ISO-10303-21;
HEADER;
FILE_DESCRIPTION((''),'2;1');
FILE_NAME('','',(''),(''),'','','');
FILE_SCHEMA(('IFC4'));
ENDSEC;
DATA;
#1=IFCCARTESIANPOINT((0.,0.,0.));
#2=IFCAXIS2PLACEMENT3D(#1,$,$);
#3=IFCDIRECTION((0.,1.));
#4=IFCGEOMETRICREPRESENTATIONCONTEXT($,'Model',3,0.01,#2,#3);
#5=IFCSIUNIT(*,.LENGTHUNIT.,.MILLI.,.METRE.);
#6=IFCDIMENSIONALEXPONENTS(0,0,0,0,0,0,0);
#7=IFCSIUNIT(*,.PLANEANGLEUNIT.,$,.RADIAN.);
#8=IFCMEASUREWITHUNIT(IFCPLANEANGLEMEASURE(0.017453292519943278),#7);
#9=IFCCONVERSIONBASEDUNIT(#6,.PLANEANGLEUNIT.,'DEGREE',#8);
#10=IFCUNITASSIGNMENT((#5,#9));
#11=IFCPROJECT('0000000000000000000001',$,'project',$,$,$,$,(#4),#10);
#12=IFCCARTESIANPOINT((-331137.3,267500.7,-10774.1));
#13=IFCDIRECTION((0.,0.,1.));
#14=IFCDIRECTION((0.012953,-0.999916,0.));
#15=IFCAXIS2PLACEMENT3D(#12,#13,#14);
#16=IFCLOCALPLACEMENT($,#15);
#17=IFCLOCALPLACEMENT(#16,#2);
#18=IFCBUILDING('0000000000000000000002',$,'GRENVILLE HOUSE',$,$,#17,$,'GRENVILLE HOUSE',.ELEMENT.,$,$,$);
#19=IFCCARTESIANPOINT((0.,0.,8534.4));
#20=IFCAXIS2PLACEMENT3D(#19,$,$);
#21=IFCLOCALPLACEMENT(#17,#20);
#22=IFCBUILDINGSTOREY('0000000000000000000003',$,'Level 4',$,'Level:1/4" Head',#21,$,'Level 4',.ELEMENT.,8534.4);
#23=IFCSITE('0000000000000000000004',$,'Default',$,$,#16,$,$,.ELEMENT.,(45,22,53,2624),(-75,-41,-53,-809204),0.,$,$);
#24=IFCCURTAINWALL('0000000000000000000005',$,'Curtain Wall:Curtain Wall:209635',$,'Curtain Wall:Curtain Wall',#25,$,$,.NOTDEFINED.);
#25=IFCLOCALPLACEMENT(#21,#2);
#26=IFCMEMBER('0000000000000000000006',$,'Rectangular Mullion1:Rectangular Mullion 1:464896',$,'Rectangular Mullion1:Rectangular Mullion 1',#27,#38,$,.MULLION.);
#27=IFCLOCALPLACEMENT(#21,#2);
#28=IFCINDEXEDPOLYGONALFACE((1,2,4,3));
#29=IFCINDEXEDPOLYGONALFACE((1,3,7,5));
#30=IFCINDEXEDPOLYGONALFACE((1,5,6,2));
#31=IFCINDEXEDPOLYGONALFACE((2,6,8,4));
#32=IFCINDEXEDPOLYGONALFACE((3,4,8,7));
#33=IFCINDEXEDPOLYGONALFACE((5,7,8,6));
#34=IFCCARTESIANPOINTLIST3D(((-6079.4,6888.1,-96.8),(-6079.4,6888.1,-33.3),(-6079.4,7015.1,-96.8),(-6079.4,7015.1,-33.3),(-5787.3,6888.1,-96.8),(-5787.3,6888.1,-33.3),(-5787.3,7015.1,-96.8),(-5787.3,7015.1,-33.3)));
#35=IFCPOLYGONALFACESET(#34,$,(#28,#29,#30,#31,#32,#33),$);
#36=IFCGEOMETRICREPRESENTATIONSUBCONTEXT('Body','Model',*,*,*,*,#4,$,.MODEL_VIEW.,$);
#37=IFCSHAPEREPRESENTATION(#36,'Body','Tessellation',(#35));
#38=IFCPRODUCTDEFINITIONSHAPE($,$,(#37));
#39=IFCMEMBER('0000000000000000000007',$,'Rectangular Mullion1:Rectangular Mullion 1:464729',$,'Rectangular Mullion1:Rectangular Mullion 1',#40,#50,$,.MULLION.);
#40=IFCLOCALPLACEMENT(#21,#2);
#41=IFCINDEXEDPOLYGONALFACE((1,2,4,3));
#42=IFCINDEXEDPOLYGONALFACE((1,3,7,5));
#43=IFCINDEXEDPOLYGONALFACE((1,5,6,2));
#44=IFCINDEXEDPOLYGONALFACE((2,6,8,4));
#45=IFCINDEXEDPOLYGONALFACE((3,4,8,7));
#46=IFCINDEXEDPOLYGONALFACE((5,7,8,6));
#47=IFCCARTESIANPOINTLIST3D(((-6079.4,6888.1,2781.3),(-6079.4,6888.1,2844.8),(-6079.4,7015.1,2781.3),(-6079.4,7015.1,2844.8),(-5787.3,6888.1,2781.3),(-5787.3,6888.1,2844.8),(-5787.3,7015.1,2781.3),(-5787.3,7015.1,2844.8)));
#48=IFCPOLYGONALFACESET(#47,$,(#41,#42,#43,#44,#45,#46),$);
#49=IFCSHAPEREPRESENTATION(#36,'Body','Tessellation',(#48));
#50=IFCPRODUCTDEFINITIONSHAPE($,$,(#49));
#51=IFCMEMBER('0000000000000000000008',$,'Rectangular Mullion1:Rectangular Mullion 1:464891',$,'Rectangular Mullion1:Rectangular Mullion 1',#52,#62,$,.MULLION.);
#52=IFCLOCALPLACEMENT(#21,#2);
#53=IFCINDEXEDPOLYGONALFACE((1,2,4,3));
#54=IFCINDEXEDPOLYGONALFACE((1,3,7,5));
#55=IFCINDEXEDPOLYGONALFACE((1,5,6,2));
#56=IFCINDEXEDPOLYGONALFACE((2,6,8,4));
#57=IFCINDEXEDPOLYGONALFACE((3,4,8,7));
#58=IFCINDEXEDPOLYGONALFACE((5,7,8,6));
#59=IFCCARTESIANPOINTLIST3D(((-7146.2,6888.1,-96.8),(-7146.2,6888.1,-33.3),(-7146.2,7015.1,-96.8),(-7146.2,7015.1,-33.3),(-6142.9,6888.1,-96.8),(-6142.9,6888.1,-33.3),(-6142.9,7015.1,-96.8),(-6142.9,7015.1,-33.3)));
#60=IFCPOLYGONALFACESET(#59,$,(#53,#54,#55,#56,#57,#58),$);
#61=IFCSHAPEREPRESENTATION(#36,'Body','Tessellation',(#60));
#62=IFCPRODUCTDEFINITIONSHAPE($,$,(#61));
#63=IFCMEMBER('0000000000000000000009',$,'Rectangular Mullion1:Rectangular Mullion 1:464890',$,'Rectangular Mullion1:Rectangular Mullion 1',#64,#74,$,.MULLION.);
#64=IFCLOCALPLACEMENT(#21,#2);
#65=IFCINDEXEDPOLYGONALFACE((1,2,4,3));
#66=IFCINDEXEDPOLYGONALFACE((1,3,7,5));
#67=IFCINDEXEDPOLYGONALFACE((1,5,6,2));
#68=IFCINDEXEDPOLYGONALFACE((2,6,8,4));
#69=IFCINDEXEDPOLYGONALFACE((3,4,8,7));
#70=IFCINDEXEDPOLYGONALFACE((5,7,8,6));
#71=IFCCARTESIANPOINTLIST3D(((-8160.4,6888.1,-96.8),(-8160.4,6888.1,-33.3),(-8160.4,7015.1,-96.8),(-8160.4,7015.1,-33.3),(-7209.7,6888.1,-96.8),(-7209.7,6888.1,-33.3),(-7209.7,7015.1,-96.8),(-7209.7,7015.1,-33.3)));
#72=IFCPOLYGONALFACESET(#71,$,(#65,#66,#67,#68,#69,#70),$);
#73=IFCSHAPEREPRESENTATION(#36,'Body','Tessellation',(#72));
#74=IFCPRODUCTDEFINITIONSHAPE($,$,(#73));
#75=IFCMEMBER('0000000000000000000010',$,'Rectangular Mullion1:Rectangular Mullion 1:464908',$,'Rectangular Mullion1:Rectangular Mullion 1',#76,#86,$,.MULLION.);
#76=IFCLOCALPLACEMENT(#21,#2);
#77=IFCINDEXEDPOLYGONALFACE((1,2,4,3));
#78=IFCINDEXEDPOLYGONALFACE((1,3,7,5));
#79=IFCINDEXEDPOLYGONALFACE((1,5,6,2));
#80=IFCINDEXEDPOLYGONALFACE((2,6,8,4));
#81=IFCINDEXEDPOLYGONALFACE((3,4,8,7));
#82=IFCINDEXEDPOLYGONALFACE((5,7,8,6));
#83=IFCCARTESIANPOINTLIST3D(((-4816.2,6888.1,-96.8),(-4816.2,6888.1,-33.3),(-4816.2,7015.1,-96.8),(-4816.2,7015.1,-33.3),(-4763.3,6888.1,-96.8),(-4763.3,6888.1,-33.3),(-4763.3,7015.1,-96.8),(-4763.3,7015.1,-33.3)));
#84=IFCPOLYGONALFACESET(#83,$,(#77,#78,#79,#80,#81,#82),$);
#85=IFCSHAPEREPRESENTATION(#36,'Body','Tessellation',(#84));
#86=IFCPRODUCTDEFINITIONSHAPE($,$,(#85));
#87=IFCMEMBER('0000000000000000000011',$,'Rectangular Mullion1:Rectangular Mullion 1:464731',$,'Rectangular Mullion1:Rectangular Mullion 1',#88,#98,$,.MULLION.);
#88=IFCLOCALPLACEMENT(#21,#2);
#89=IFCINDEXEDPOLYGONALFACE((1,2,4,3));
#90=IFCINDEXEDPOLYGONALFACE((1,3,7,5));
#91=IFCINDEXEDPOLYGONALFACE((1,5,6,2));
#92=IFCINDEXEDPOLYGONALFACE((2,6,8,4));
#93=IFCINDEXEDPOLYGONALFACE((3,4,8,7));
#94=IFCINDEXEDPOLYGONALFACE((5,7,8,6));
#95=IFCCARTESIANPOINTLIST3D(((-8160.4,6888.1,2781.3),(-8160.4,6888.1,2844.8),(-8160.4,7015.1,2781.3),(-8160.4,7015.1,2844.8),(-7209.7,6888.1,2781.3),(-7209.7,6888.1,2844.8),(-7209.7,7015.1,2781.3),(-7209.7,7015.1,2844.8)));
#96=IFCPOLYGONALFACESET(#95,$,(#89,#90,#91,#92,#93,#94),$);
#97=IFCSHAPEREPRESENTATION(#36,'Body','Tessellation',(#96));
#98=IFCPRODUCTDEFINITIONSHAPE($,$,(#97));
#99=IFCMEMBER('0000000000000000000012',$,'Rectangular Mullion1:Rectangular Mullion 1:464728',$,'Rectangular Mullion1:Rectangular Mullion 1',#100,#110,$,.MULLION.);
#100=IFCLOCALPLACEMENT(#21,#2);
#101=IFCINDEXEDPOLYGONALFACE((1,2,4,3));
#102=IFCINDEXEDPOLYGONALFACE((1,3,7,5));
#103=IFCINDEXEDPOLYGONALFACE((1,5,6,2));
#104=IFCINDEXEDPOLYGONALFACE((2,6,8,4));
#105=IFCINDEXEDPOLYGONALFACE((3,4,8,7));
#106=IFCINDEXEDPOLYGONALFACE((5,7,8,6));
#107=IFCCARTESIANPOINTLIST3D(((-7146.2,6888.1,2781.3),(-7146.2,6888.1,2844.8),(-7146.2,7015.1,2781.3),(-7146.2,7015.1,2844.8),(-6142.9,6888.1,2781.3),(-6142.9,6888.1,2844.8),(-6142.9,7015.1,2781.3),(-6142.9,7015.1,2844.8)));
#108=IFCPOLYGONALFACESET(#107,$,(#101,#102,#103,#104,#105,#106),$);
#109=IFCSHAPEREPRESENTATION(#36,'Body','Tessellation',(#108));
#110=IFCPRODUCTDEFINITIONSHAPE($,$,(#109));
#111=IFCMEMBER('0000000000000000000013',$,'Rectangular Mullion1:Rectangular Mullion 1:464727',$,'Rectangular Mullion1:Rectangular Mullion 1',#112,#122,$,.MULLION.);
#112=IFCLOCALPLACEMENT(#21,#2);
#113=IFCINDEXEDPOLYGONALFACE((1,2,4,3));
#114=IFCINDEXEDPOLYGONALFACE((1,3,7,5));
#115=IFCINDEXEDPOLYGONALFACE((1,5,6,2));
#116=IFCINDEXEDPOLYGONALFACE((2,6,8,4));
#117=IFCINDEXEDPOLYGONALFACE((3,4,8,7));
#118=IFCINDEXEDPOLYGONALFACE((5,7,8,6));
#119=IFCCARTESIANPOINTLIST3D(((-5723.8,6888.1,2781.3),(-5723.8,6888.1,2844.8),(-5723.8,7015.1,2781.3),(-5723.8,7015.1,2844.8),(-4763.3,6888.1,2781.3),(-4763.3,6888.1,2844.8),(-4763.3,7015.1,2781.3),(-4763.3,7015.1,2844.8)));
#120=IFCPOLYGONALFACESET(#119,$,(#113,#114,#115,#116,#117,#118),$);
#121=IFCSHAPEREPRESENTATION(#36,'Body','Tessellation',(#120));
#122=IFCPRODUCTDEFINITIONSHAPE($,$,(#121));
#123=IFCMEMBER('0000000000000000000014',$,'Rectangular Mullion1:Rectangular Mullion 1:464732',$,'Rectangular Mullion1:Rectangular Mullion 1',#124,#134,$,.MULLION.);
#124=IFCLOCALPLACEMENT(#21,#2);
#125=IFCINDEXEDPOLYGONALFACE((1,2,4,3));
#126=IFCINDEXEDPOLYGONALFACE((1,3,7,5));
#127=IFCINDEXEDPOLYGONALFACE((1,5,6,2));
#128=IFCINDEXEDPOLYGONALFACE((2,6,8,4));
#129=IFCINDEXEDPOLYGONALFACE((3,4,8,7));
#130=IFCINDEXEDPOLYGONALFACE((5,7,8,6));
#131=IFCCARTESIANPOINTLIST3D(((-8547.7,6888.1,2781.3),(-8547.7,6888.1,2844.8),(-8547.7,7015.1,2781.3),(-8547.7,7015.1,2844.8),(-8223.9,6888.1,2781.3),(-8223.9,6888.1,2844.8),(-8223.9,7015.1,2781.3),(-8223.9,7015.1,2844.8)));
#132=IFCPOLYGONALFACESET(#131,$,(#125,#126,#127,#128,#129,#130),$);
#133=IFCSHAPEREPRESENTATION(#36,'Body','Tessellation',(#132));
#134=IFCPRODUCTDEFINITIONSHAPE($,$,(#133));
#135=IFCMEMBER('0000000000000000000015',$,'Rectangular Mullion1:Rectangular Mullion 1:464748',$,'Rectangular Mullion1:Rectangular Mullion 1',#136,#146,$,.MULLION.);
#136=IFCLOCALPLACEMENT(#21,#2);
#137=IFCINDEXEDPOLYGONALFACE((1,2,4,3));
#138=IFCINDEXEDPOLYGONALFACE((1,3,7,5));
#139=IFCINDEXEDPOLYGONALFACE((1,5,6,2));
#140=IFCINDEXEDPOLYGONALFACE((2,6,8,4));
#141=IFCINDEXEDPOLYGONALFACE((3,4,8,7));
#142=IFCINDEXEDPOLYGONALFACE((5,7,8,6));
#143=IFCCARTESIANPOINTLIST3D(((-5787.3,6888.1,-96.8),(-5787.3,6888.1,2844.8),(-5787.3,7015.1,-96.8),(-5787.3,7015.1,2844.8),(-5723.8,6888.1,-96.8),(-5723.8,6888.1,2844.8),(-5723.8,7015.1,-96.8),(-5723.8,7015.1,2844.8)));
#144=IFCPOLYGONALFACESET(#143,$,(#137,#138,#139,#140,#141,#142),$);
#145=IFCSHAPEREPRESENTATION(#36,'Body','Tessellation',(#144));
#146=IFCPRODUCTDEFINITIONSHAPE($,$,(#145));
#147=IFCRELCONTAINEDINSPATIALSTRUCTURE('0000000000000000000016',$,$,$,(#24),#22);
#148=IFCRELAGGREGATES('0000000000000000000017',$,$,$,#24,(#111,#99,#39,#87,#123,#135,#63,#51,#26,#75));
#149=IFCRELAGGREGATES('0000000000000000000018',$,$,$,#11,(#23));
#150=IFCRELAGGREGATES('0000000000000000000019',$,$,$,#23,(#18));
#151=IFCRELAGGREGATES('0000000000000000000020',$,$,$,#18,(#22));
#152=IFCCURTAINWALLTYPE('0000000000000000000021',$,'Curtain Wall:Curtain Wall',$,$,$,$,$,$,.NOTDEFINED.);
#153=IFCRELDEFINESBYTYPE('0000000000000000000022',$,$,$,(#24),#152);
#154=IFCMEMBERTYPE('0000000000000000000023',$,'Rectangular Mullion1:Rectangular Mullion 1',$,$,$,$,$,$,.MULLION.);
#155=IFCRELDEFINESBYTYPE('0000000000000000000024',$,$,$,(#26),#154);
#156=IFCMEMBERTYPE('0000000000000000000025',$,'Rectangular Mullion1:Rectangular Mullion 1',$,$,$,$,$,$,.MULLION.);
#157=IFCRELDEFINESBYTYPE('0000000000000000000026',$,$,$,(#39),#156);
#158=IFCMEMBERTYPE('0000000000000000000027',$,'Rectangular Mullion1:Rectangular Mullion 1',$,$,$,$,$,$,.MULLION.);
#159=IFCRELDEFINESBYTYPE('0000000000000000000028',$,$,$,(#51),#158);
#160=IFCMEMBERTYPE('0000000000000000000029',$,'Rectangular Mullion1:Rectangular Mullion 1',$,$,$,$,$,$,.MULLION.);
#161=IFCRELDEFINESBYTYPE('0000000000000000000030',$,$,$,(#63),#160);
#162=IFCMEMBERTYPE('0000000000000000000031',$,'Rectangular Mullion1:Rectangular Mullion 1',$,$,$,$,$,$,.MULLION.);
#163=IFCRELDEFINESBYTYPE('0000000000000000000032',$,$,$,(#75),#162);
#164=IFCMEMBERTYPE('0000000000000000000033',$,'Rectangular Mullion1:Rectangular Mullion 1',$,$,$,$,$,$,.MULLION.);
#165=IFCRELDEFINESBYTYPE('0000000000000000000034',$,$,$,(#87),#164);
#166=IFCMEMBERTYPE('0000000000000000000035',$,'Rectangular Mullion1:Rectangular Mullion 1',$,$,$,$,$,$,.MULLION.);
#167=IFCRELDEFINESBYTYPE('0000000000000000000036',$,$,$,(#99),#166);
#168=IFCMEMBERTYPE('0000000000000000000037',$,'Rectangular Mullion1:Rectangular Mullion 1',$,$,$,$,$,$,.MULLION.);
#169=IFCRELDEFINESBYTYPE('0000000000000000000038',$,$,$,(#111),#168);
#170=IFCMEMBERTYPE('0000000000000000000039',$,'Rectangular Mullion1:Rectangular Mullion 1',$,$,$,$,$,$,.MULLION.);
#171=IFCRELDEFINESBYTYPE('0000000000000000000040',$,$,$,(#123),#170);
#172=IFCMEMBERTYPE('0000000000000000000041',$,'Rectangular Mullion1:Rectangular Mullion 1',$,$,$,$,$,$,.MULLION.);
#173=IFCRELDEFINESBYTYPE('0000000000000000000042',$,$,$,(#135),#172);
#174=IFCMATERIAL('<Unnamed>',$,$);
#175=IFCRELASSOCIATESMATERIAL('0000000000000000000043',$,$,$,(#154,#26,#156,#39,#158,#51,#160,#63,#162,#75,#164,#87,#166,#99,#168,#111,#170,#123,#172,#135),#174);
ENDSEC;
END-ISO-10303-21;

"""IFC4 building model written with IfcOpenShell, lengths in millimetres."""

from ifc_helpers import new_model, entity, si_unit, converted_unit, direction, frame, origin, place, context, subcontext, project, spatial, indexed_curve, outline, extrude, source, transform, mapped, material, type_object, type_shapes, element, aggregate, save


model = new_model("IFC4")

# Units and contexts
model_context = context("Model", 3, precision=0.01, world=origin(), true_north=direction((0.0, 1.0)))
body_context = subcontext(model_context, "Body", "Model", "MODEL_VIEW")
ifc_project = project(units=[si_unit("LENGTHUNIT", "METRE", prefix="MILLI"), converted_unit("PLANEANGLEUNIT", "DEGREE", entity("IfcPlaneAngleMeasure", 0.017453292519943278), si_unit("PLANEANGLEUNIT", "RADIAN"), dimensions=[0, 0, 0, 0, 0, 0, 0])], contexts=[model_context])

# Site, building, storey
site_placement = place(None, frame((-331137.3, 267500.7, -10774.1), z_axis=(0.0, 0.0, 1.0), x_axis=(0.012953, -0.999916, 0.0)))
site = spatial("IfcSite", under=ifc_project, at=site_placement, Name="Default", CompositionType="ELEMENT", RefLatitude=(45, 22, 53, 2624), RefLongitude=(-75, -41, -53, -809204), RefElevation=0.0)
building_placement = place(site_placement, origin())
building = spatial("IfcBuilding", under=site, at=building_placement, Name="GRENVILLE HOUSE", LongName="GRENVILLE HOUSE", CompositionType="ELEMENT")
storey_placement = place(building_placement, frame((0.0, 0.0, 8534.4)))
storey = spatial("IfcBuildingStorey", under=building, at=storey_placement, Name="Level 4", ObjectType="Level:1/4\" Head", LongName="Level 4", CompositionType="ELEMENT", Elevation=8534.4)

# Curtain wall, members
curtain_wall_type = type_object("IfcCurtainWallType", Name="Curtain Wall:Curtain Wall", PredefinedType="NOTDEFINED")
curtain_wall_placement = place(storey_placement, frame((0.0, 0.0, -8534.4)))
curtain_wall = element("IfcCurtainWall", 1, at=curtain_wall_placement, inside=storey, type_object=curtain_wall_type, Name="Curtain Wall:Curtain Wall:209635", ObjectType="Curtain Wall:Curtain Wall", PredefinedType="NOTDEFINED")
ifc_material_1 = material(Name="<Unnamed>")
member_type_1 = type_object("IfcMemberType", Name="Rectangular Mullion1:Rectangular Mullion 1", PredefinedType="MULLION", material=ifc_material_1)
shared_shape_1 = source(origin(), body_context, "Body", "SweptSolid", [
    extrude(outline(indexed_curve([(-31.8, -63.5), (31.8, -63.5), (31.8, 63.5), (-31.8, 63.5), (-31.8, -63.5)], self_intersect=False)), frame((-31.8, 0.0, -292.1), z_axis=(0.0, 0.0, 1.0), x_axis=(-1.0, 0.0, 0.0)), (0.0, 0.0, 1.0), 292.1),
])
type_shapes(member_type_1, [shared_shape_1])
member_1_placement = place(curtain_wall_placement, frame((-5787.3, 6951.6, 8437.6), z_axis=(1.0, 0.0, 0.0), x_axis=(0.0, 0.0, -1.0)))
member_1 = element("IfcMember", 2, at=member_1_placement, type_object=member_type_1, material=ifc_material_1, Name="Rectangular Mullion1:Rectangular Mullion 1:464896", ObjectType="Rectangular Mullion1:Rectangular Mullion 1", PredefinedType="MULLION", context=body_context, shape_type="MappedRepresentation", body=[
    mapped(shared_shape_1, transform((0.0, 0.0, 0.0), scale=1.0)),
])
member_type_2 = type_object("IfcMemberType", Name="Rectangular Mullion1:Rectangular Mullion 1", PredefinedType="MULLION", material=ifc_material_1)
shared_shape_2 = source(origin(), body_context, "Body", "SweptSolid", [
    extrude(outline(indexed_curve([(-31.8, -63.5), (31.8, -63.5), (31.8, 63.5), (-31.8, 63.5), (-31.8, -63.5)], self_intersect=False)), frame((-31.8, 0.0, -292.1), z_axis=(0.0, 0.0, 1.0), x_axis=(-1.0, 0.0, 0.0)), (0.0, 0.0, 1.0), 292.1),
])
type_shapes(member_type_2, [shared_shape_2])
member_2_placement = place(curtain_wall_placement, frame((-6079.4, 6951.6, 11379.2), z_axis=(-1.0, 0.0, 0.0), x_axis=(0.0, 0.0, 1.0)))
member_2 = element("IfcMember", 3, at=member_2_placement, type_object=member_type_2, material=ifc_material_1, Name="Rectangular Mullion1:Rectangular Mullion 1:464729", ObjectType="Rectangular Mullion1:Rectangular Mullion 1", PredefinedType="MULLION", context=body_context, shape_type="MappedRepresentation", body=[
    mapped(shared_shape_2, transform((0.0, 0.0, 0.0), scale=1.0)),
])
member_type_3 = type_object("IfcMemberType", Name="Rectangular Mullion1:Rectangular Mullion 1", PredefinedType="MULLION", material=ifc_material_1)
shared_shape_3 = source(origin(), body_context, "Body", "SweptSolid", [
    extrude(outline(indexed_curve([(-31.8, -63.5), (31.8, -63.5), (31.8, 63.5), (-31.8, 63.5), (-31.8, -63.5)], self_intersect=False)), frame((-31.8, 0.0, -1003.3), z_axis=(0.0, 0.0, 1.0), x_axis=(-1.0, 0.0, 0.0)), (0.0, 0.0, 1.0), 1003.3),
])
type_shapes(member_type_3, [shared_shape_3])
member_3_placement = place(curtain_wall_placement, frame((-6142.9, 6951.6, 8437.6), z_axis=(1.0, 0.0, 0.0), x_axis=(0.0, 0.0, -1.0)))
member_3 = element("IfcMember", 4, at=member_3_placement, type_object=member_type_3, material=ifc_material_1, Name="Rectangular Mullion1:Rectangular Mullion 1:464891", ObjectType="Rectangular Mullion1:Rectangular Mullion 1", PredefinedType="MULLION", context=body_context, shape_type="MappedRepresentation", body=[
    mapped(shared_shape_3, transform((0.0, 0.0, 0.0), scale=1.0)),
])
member_type_4 = type_object("IfcMemberType", Name="Rectangular Mullion1:Rectangular Mullion 1", PredefinedType="MULLION", material=ifc_material_1)
shared_shape_4 = source(origin(), body_context, "Body", "SweptSolid", [
    extrude(outline(indexed_curve([(-31.8, -63.5), (31.8, -63.5), (31.8, 63.5), (-31.8, 63.5), (-31.8, -63.5)], self_intersect=False)), frame((-31.8, 0.0, -950.7), z_axis=(0.0, 0.0, 1.0), x_axis=(-1.0, 0.0, 0.0)), (0.0, 0.0, 1.0), 950.7),
])
type_shapes(member_type_4, [shared_shape_4])
member_4_placement = place(curtain_wall_placement, frame((-7209.7, 6951.6, 8437.6), z_axis=(1.0, 0.0, 0.0), x_axis=(0.0, 0.0, -1.0)))
member_4 = element("IfcMember", 5, at=member_4_placement, type_object=member_type_4, material=ifc_material_1, Name="Rectangular Mullion1:Rectangular Mullion 1:464890", ObjectType="Rectangular Mullion1:Rectangular Mullion 1", PredefinedType="MULLION", context=body_context, shape_type="MappedRepresentation", body=[
    mapped(shared_shape_4, transform((0.0, 0.0, 0.0), scale=1.0)),
])
member_type_5 = type_object("IfcMemberType", Name="Rectangular Mullion1:Rectangular Mullion 1", PredefinedType="MULLION", material=ifc_material_1)
shared_shape_5 = source(origin(), body_context, "Body", "SweptSolid", [
    extrude(outline(indexed_curve([(-31.8, -63.5), (31.8, -63.5), (31.8, 63.5), (-31.8, 63.5), (-31.8, -63.5)], self_intersect=False)), frame((-31.8, 0.0, -52.9), z_axis=(0.0, 0.0, 1.0), x_axis=(-1.0, 0.0, 0.0)), (0.0, 0.0, 1.0), 52.9),
])
type_shapes(member_type_5, [shared_shape_5])
member_5_placement = place(curtain_wall_placement, frame((-4763.3, 6951.6, 8437.6), z_axis=(1.0, 0.0, 0.0), x_axis=(0.0, 0.0, -1.0)))
member_5 = element("IfcMember", 6, at=member_5_placement, type_object=member_type_5, material=ifc_material_1, Name="Rectangular Mullion1:Rectangular Mullion 1:464908", ObjectType="Rectangular Mullion1:Rectangular Mullion 1", PredefinedType="MULLION", context=body_context, shape_type="MappedRepresentation", body=[
    mapped(shared_shape_5, transform((0.0, 0.0, 0.0), scale=1.0)),
])
member_type_6 = type_object("IfcMemberType", Name="Rectangular Mullion1:Rectangular Mullion 1", PredefinedType="MULLION", material=ifc_material_1)
shared_shape_6 = source(origin(), body_context, "Body", "SweptSolid", [
    extrude(outline(indexed_curve([(-31.8, -63.5), (31.8, -63.5), (31.8, 63.5), (-31.8, 63.5), (-31.8, -63.5)], self_intersect=False)), frame((-31.8, 0.0, -950.7), z_axis=(0.0, 0.0, 1.0), x_axis=(-1.0, 0.0, 0.0)), (0.0, 0.0, 1.0), 950.7),
])
type_shapes(member_type_6, [shared_shape_6])
member_6_placement = place(curtain_wall_placement, frame((-8160.4, 6951.6, 11379.2), z_axis=(-1.0, 0.0, 0.0), x_axis=(0.0, 0.0, 1.0)))
member_6 = element("IfcMember", 7, at=member_6_placement, type_object=member_type_6, material=ifc_material_1, Name="Rectangular Mullion1:Rectangular Mullion 1:464731", ObjectType="Rectangular Mullion1:Rectangular Mullion 1", PredefinedType="MULLION", context=body_context, shape_type="MappedRepresentation", body=[
    mapped(shared_shape_6, transform((0.0, 0.0, 0.0), scale=1.0)),
])
member_type_7 = type_object("IfcMemberType", Name="Rectangular Mullion1:Rectangular Mullion 1", PredefinedType="MULLION", material=ifc_material_1)
shared_shape_7 = source(origin(), body_context, "Body", "SweptSolid", [
    extrude(outline(indexed_curve([(-31.8, -63.5), (31.8, -63.5), (31.8, 63.5), (-31.8, 63.5), (-31.8, -63.5)], self_intersect=False)), frame((-31.8, 0.0, -1003.3), z_axis=(0.0, 0.0, 1.0), x_axis=(-1.0, 0.0, 0.0)), (0.0, 0.0, 1.0), 1003.3),
])
type_shapes(member_type_7, [shared_shape_7])
member_7_placement = place(curtain_wall_placement, frame((-7146.2, 6951.6, 11379.2), z_axis=(-1.0, 0.0, 0.0), x_axis=(0.0, 0.0, 1.0)))
member_7 = element("IfcMember", 8, at=member_7_placement, type_object=member_type_7, material=ifc_material_1, Name="Rectangular Mullion1:Rectangular Mullion 1:464728", ObjectType="Rectangular Mullion1:Rectangular Mullion 1", PredefinedType="MULLION", context=body_context, shape_type="MappedRepresentation", body=[
    mapped(shared_shape_7, transform((0.0, 0.0, 0.0), scale=1.0)),
])
member_type_8 = type_object("IfcMemberType", Name="Rectangular Mullion1:Rectangular Mullion 1", PredefinedType="MULLION", material=ifc_material_1)
shared_shape_8 = source(origin(), body_context, "Body", "SweptSolid", [
    extrude(outline(indexed_curve([(-31.8, -63.5), (31.8, -63.5), (31.8, 63.5), (-31.8, 63.5), (-31.8, -63.5)], self_intersect=False)), frame((-31.8, 0.0, -960.4), z_axis=(0.0, 0.0, 1.0), x_axis=(-1.0, 0.0, 0.0)), (0.0, 0.0, 1.0), 960.4),
])
type_shapes(member_type_8, [shared_shape_8])
member_8_placement = place(curtain_wall_placement, frame((-5723.8, 6951.6, 11379.2), z_axis=(-1.0, 0.0, 0.0), x_axis=(0.0, 0.0, 1.0)))
member_8 = element("IfcMember", 9, at=member_8_placement, type_object=member_type_8, material=ifc_material_1, Name="Rectangular Mullion1:Rectangular Mullion 1:464727", ObjectType="Rectangular Mullion1:Rectangular Mullion 1", PredefinedType="MULLION", context=body_context, shape_type="MappedRepresentation", body=[
    mapped(shared_shape_8, transform((0.0, 0.0, 0.0), scale=1.0)),
])
member_type_9 = type_object("IfcMemberType", Name="Rectangular Mullion1:Rectangular Mullion 1", PredefinedType="MULLION", material=ifc_material_1)
shared_shape_9 = source(origin(), body_context, "Body", "SweptSolid", [
    extrude(outline(indexed_curve([(-31.8, -63.5), (31.8, -63.5), (31.8, 63.5), (-31.8, 63.5), (-31.8, -63.5)], self_intersect=False)), frame((-31.8, 0.0, -323.9), z_axis=(0.0, 0.0, 1.0), x_axis=(-1.0, 0.0, 0.0)), (0.0, 0.0, 1.0), 323.9),
])
type_shapes(member_type_9, [shared_shape_9])
member_9_placement = place(curtain_wall_placement, frame((-8547.7, 6951.6, 11379.2), z_axis=(-1.0, 0.0, 0.0), x_axis=(0.0, 0.0, 1.0)))
member_9 = element("IfcMember", 10, at=member_9_placement, type_object=member_type_9, material=ifc_material_1, Name="Rectangular Mullion1:Rectangular Mullion 1:464732", ObjectType="Rectangular Mullion1:Rectangular Mullion 1", PredefinedType="MULLION", context=body_context, shape_type="MappedRepresentation", body=[
    mapped(shared_shape_9, transform((0.0, 0.0, 0.0), scale=1.0)),
])
member_type_10 = type_object("IfcMemberType", Name="Rectangular Mullion1:Rectangular Mullion 1", PredefinedType="MULLION", material=ifc_material_1)
shared_shape_10 = source(origin(), body_context, "Body", "SweptSolid", [
    extrude(outline(indexed_curve([(-31.8, -63.5), (31.8, -63.5), (31.8, 63.5), (-31.8, 63.5), (-31.8, -63.5)], self_intersect=False)), frame((0.0, 0.0, -2941.6), z_axis=(0.0, 0.0, 1.0), x_axis=(-1.0, 0.0, 0.0)), (0.0, 0.0, 1.0), 2941.6),
])
type_shapes(member_type_10, [shared_shape_10])
member_10_placement = place(curtain_wall_placement, frame((-5755.5, 6951.6, 8437.6), z_axis=(0.0, 0.0, -1.0), x_axis=(-1.0, 0.0, 0.0)))
member_10 = element("IfcMember", 11, at=member_10_placement, type_object=member_type_10, material=ifc_material_1, Name="Rectangular Mullion1:Rectangular Mullion 1:464748", ObjectType="Rectangular Mullion1:Rectangular Mullion 1", PredefinedType="MULLION", context=body_context, shape_type="MappedRepresentation", body=[
    mapped(shared_shape_10, transform((0.0, 0.0, 0.0), scale=1.0)),
])
aggregate(curtain_wall, [member_8, member_7, member_2, member_6, member_9, member_10, member_4, member_3, member_1, member_5])

save(model, "model.ifc")
